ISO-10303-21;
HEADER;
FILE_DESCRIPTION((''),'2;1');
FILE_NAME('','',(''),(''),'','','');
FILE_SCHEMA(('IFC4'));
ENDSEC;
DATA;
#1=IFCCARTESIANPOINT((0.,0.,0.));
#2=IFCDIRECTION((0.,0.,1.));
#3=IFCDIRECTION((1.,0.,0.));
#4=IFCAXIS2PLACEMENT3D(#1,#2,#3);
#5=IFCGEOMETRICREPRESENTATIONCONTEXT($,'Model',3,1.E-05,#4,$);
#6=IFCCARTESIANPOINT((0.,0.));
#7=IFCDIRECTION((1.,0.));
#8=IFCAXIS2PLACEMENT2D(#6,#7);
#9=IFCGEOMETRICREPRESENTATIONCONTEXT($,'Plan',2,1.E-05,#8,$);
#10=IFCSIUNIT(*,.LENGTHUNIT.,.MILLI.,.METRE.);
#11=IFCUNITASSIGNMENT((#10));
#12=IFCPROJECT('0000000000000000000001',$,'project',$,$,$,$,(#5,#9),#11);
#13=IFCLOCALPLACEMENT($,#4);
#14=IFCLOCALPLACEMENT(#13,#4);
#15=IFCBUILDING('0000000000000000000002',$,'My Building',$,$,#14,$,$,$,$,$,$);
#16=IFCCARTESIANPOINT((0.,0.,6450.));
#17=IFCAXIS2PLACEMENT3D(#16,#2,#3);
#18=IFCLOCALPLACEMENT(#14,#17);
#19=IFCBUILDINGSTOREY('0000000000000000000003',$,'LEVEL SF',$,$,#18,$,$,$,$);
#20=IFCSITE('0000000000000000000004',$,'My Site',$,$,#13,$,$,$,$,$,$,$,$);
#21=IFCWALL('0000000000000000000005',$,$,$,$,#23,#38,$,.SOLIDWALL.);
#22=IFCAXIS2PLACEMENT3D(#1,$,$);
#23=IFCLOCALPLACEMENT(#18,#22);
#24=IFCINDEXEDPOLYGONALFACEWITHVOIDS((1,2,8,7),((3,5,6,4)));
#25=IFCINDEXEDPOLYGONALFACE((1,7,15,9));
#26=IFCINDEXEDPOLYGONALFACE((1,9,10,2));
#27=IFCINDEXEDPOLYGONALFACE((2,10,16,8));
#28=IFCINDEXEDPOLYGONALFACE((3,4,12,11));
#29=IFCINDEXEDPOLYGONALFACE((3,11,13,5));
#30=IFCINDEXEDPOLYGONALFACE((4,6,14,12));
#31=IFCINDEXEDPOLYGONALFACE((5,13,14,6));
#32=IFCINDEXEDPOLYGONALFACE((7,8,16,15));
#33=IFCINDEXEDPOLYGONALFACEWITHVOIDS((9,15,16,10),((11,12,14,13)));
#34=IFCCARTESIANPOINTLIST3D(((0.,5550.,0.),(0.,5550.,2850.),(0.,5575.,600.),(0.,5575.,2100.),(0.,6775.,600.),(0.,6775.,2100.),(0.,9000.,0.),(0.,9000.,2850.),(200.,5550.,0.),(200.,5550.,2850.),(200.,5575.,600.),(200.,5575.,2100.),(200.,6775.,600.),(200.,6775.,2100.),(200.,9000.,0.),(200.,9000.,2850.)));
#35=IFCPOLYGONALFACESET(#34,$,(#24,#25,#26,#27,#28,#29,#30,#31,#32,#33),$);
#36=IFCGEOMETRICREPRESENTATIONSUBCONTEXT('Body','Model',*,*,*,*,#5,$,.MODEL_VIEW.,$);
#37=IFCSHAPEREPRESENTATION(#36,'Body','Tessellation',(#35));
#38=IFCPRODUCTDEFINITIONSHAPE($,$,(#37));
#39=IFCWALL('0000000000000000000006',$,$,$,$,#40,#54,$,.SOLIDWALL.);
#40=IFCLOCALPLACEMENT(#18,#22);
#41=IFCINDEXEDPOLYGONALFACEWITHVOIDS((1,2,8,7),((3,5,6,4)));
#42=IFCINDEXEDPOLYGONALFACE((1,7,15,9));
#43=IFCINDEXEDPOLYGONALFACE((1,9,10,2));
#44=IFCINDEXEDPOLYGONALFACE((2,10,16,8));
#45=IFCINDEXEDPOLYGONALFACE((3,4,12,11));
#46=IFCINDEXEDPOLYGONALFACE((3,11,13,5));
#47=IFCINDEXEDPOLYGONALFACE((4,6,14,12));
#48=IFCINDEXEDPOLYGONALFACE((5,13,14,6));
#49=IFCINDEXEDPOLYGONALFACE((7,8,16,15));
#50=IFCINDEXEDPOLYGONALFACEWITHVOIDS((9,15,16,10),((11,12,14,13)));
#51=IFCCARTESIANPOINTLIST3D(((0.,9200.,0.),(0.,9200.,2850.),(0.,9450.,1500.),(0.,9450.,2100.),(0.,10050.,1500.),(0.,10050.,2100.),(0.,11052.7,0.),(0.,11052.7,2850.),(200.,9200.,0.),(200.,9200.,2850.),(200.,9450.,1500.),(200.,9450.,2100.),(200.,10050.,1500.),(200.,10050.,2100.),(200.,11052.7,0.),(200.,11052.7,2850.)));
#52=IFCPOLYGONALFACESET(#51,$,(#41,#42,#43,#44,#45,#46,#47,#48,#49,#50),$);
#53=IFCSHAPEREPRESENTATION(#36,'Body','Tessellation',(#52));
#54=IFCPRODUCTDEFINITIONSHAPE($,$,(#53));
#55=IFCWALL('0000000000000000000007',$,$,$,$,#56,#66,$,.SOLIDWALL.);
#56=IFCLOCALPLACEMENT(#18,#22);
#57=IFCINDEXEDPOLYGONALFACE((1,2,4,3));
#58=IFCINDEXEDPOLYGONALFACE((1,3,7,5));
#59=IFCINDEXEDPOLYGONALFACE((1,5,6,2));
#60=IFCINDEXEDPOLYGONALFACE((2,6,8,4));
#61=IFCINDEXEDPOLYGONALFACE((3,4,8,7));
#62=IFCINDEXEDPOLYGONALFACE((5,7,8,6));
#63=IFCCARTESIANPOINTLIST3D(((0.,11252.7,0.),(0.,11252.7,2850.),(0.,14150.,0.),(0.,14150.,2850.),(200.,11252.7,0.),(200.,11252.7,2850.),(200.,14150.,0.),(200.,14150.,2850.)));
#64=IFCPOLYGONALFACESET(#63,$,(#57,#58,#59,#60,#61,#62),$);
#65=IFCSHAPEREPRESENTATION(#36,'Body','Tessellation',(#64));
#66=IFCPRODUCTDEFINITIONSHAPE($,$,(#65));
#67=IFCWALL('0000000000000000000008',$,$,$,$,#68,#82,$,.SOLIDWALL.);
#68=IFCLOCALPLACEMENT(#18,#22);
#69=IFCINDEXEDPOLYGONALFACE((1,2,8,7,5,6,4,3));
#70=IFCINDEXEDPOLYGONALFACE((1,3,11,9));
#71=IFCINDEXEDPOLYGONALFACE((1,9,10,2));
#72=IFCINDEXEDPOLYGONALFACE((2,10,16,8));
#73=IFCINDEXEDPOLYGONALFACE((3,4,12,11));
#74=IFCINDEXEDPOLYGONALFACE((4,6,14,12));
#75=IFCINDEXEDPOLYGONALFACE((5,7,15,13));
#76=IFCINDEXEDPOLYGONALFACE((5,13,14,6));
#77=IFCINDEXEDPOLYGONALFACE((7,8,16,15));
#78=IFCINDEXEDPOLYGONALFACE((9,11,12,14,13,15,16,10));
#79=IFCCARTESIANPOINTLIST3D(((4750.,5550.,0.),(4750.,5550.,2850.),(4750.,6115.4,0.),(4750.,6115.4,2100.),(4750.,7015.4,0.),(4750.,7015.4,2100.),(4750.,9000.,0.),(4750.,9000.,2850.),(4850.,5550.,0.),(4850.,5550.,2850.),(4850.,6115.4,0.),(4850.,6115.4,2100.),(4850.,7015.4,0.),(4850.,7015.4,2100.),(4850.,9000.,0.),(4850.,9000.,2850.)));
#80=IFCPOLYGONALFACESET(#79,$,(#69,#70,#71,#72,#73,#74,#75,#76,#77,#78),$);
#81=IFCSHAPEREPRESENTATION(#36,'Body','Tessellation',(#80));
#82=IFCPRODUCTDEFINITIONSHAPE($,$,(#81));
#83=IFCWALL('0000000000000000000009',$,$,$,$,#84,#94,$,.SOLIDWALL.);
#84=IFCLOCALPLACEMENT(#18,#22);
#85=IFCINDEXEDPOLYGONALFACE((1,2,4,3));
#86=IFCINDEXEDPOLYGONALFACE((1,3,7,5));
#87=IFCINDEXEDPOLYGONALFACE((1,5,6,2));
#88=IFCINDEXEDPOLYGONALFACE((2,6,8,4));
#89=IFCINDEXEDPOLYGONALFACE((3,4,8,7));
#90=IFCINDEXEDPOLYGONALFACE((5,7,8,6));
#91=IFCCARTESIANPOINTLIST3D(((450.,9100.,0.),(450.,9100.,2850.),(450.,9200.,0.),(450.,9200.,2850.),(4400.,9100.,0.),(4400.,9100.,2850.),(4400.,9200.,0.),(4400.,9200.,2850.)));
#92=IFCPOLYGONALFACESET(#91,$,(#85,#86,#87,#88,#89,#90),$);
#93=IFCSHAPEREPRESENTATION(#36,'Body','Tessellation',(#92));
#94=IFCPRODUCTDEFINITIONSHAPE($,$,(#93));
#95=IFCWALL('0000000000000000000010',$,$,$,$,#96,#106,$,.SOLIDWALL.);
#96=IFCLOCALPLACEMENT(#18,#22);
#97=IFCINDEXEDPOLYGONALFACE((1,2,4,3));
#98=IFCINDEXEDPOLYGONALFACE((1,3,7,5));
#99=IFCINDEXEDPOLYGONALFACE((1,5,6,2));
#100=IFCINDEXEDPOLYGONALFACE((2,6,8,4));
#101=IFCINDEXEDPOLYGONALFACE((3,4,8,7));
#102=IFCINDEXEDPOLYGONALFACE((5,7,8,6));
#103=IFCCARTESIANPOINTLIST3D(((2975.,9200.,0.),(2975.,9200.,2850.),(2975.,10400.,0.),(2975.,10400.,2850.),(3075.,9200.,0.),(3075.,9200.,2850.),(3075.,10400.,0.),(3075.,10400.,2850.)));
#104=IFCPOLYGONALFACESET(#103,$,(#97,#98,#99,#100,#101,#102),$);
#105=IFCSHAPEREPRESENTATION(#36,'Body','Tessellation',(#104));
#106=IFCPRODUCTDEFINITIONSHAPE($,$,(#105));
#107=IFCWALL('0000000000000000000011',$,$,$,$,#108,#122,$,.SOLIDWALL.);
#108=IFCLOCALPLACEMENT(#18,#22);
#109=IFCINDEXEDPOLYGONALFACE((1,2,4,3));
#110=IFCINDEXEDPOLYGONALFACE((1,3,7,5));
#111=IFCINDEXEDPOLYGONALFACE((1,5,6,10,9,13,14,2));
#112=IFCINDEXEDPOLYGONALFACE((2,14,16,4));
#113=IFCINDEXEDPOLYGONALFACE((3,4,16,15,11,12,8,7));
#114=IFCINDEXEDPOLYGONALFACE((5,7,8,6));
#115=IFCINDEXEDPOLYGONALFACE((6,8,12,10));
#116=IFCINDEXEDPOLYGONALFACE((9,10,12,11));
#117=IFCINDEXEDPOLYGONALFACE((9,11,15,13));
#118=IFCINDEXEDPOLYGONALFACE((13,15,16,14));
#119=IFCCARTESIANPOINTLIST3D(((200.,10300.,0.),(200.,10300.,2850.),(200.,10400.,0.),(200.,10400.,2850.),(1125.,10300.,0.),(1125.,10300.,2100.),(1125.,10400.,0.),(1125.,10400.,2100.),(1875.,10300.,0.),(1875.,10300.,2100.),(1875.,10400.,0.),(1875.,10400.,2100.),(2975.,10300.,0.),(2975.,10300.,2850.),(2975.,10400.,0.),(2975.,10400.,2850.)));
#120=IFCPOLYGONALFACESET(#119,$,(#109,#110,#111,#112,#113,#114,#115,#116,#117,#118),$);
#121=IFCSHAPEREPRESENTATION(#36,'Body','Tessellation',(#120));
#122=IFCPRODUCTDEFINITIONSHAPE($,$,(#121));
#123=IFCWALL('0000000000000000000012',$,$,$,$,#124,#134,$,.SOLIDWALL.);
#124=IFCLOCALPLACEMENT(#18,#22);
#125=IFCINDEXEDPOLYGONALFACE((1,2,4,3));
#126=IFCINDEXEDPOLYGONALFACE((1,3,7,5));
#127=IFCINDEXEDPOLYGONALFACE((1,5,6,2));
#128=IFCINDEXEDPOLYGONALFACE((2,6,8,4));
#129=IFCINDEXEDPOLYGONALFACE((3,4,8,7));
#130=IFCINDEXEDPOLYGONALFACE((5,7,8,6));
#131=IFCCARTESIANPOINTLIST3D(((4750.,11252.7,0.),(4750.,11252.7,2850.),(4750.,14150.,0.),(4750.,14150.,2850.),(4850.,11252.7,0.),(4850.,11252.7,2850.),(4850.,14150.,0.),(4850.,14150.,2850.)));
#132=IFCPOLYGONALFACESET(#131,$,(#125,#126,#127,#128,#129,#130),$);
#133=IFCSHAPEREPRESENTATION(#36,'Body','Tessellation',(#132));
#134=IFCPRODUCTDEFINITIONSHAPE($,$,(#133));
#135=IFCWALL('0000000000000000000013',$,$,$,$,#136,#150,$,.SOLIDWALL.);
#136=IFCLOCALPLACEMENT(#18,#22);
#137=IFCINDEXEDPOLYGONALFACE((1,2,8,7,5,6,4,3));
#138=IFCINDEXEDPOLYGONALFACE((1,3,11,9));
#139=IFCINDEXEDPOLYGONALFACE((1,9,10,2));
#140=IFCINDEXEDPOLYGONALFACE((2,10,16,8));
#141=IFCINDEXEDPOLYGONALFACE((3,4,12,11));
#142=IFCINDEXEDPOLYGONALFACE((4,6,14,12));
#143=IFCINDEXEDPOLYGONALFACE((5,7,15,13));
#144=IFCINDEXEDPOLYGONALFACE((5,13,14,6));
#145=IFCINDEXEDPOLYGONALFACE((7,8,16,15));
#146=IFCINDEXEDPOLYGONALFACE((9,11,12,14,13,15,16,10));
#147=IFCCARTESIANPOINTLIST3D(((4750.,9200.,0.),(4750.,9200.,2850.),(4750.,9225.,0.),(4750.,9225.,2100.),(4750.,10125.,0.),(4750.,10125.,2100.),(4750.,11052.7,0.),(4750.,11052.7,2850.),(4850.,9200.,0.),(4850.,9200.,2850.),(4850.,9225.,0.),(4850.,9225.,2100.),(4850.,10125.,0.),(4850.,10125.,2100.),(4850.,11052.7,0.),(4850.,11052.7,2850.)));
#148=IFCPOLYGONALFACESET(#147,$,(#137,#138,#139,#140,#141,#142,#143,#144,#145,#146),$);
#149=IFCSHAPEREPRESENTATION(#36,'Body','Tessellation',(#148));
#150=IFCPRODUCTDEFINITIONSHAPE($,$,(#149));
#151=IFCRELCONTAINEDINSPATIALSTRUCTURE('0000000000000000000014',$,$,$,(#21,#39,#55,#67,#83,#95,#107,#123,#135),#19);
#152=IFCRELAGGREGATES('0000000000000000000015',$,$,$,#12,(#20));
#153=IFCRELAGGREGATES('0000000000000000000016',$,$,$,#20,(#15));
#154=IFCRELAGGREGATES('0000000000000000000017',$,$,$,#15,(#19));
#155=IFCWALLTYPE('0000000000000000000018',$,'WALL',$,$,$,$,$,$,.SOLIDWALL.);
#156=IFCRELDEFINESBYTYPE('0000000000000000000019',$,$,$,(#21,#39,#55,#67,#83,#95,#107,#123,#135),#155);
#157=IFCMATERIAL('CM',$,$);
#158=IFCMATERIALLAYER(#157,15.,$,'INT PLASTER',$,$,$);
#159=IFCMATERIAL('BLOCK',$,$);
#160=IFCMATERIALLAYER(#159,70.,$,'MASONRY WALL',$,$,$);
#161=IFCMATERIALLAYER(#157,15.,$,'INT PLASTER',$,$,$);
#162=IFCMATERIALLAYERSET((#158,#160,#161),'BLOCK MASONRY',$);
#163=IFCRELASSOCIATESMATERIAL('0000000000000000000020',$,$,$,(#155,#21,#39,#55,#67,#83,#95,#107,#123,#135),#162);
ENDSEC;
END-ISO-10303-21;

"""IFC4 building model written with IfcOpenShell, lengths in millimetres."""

from ifc_helpers import new_model, si_unit, frame, origin_with_axes, origin_2d_with_axis, place, context, subcontext, project, spatial, indexed_curve, outline, extrude, material, layer, layer_set, layer_usage, type_object, element, save


model = new_model("IFC4")

# Units and contexts
model_context = context("Model", 3, precision=1e-05, world=origin_with_axes())
plan_context = context("Plan", 2, precision=1e-05, world=origin_2d_with_axis())
body_context = subcontext(model_context, "Body", "Model", "MODEL_VIEW")
ifc_project = project(units=[si_unit("LENGTHUNIT", "METRE", prefix="MILLI")], contexts=[model_context, plan_context])

# Site, building, storey
site_placement = place(None, origin_with_axes())
site = spatial("IfcSite", under=ifc_project, at=site_placement, Name="My Site")
building_placement = place(site_placement, origin_with_axes())
building = spatial("IfcBuilding", under=site, at=building_placement, Name="My Building")
storey_placement = place(building_placement, frame((0.0, 0.0, 6450.0), z_axis=(0.0, 0.0, 1.0), x_axis=(1.0, 0.0, 0.0)))
storey = spatial("IfcBuildingStorey", under=building, at=storey_placement, Name="LEVEL SF")

# Shared definitions
ifc_material_1 = material(Name="CM")
ifc_layer_1 = layer(ifc_material_1, 15.0, Name="INT PLASTER")
ifc_material_2 = material(Name="BLOCK")
ifc_layer_2 = layer(ifc_material_2, 70.0, Name="MASONRY WALL")
ifc_layer_3 = layer(ifc_material_1, 15.0, Name="INT PLASTER")
ifc_layer_set = layer_set([ifc_layer_1, ifc_layer_2, ifc_layer_3], Name="BLOCK MASONRY")
wall_type = type_object("IfcWallType", Name="WALL", PredefinedType="SOLIDWALL", material=ifc_layer_set)

# Walls, openings
ifc_layer_usage_1 = layer_usage(ifc_layer_set, "AXIS2", "POSITIVE", 0.0)
wall_1_placement = place(storey_placement, frame((200.0, 5550.0, 0.0), z_axis=(0.0, 0.0, 1.0), x_axis=(0.0, 1.0, 0.0)))
wall_1 = element("IfcWall", 1, at=wall_1_placement, inside=storey, type_object=wall_type, material=ifc_layer_usage_1, PredefinedType="SOLIDWALL", context=body_context, shape_type="SweptSolid", body=[
    extrude(outline(indexed_curve([(0.0, 0.0), (0.0, 200.0), (3450.0, 200.0), (3450.0, 0.0), (0.0, 0.0)], self_intersect=False)), origin_with_axes(), (0.0, 0.0, 1.0), 2850.0),
])
opening_1_placement = place(wall_1_placement, frame((25.0, 0.0, 600.0), z_axis=(0.0, 0.0, 1.0), x_axis=(1.0, 0.0, 0.0)))
element("IfcOpeningElement", 2, at=opening_1_placement, cuts=wall_1, PredefinedType="OPENING", context=body_context, shape_type="SweptSolid", body=[
    extrude(outline(indexed_curve([(0.0, 0.0), (0.0, 400.0), (1200.0, 400.0), (1200.0, 0.0), (0.0, 0.0)], self_intersect=False)), frame((0.0, -100.0, 0.0), z_axis=(0.0, 0.0, 1.0), x_axis=(1.0, 0.0, 0.0)), (0.0, 0.0, 1.0), 1500.0),
])
ifc_layer_usage_2 = layer_usage(ifc_layer_set, "AXIS2", "POSITIVE", 0.0)
wall_2_placement = place(storey_placement, frame((200.0, 9200.0, 0.0), z_axis=(0.0, 0.0, 1.0), x_axis=(0.0, 1.0, 0.0)))
wall_2 = element("IfcWall", 3, at=wall_2_placement, inside=storey, type_object=wall_type, material=ifc_layer_usage_2, PredefinedType="SOLIDWALL", context=body_context, shape_type="SweptSolid", body=[
    extrude(outline(indexed_curve([(0.0, 0.0), (0.0, 200.0), (1852.7, 200.0), (1852.7, 0.0), (0.0, 0.0)], self_intersect=False)), origin_with_axes(), (0.0, 0.0, 1.0), 2850.0),
])
opening_2_placement = place(wall_2_placement, frame((250.0, 0.0, 1500.0), z_axis=(0.0, 0.0, 1.0), x_axis=(1.0, 0.0, 0.0)))
element("IfcOpeningElement", 4, at=opening_2_placement, cuts=wall_2, PredefinedType="OPENING", context=body_context, shape_type="SweptSolid", body=[
    extrude(outline(indexed_curve([(0.0, 0.0), (0.0, 400.0), (600.0, 400.0), (600.0, 0.0), (0.0, 0.0)], self_intersect=False)), frame((0.0, -100.0, 0.0), z_axis=(0.0, 0.0, 1.0), x_axis=(1.0, 0.0, 0.0)), (0.0, 0.0, 1.0), 600.0),
])

# Wall
ifc_layer_usage_3 = layer_usage(ifc_layer_set, "AXIS2", "POSITIVE", 0.0)
wall_3_placement = place(storey_placement, frame((200.0, 11252.7, 0.0), z_axis=(0.0, 0.0, 1.0), x_axis=(0.0, 1.0, 0.0)))
element("IfcWall", 5, at=wall_3_placement, inside=storey, type_object=wall_type, material=ifc_layer_usage_3, PredefinedType="SOLIDWALL", context=body_context, shape_type="SweptSolid", body=[
    extrude(outline(indexed_curve([(0.0, 0.0), (0.0, 200.0), (2897.3, 200.0), (2897.3, 0.0), (0.0, 0.0)], self_intersect=False)), origin_with_axes(), (0.0, 0.0, 1.0), 2850.0),
])

# Wall, opening
ifc_layer_usage_4 = layer_usage(ifc_layer_set, "AXIS2", "POSITIVE", 0.0)
wall_4_placement = place(storey_placement, frame((4850.0, 5550.0, 0.0), z_axis=(0.0, 0.0, 1.0), x_axis=(0.0, 1.0, 0.0)))
wall_4 = element("IfcWall", 6, at=wall_4_placement, inside=storey, type_object=wall_type, material=ifc_layer_usage_4, PredefinedType="SOLIDWALL", context=body_context, shape_type="SweptSolid", body=[
    extrude(outline(indexed_curve([(0.0, 0.0), (0.0, 100.0), (3450.0, 100.0), (3450.0, 0.0), (0.0, 0.0)], self_intersect=False)), origin_with_axes(), (0.0, 0.0, 1.0), 2850.0),
])
opening_3_placement = place(wall_4_placement, frame((565.4, 0.0, 0.0), z_axis=(0.0, 0.0, 1.0), x_axis=(1.0, 0.0, 0.0)))
element("IfcOpeningElement", 7, at=opening_3_placement, cuts=wall_4, PredefinedType="OPENING", context=body_context, shape_type="SweptSolid", body=[
    extrude(outline(indexed_curve([(0.0, 0.0), (0.0, 400.0), (900.0, 400.0), (900.0, 0.0), (0.0, 0.0)], self_intersect=False)), frame((0.0, -100.0, 0.0), z_axis=(0.0, 0.0, 1.0), x_axis=(1.0, 0.0, 0.0)), (0.0, 0.0, 1.0), 2100.0),
])

# Walls
ifc_layer_usage_5 = layer_usage(ifc_layer_set, "AXIS2", "POSITIVE", 0.0)
wall_5_placement = place(storey_placement, frame((450.0, 9200.0, 0.0), z_axis=(0.0, 0.0, 1.0), x_axis=(0.0, -1.0, 0.0)))
element("IfcWall", 8, at=wall_5_placement, inside=storey, type_object=wall_type, material=ifc_layer_usage_5, PredefinedType="SOLIDWALL", context=body_context, shape_type="SweptSolid", body=[
    extrude(outline(indexed_curve([(0.0, 0.0), (0.0, 3950.0), (100.0, 3950.0), (100.0, 0.0), (0.0, 0.0)], self_intersect=False)), origin_with_axes(), (0.0, 0.0, 1.0), 2850.0),
])
ifc_layer_usage_6 = layer_usage(ifc_layer_set, "AXIS2", "POSITIVE", 0.0)
wall_6_placement = place(storey_placement, frame((3075.0, 9200.0, 0.0), z_axis=(0.0, 0.0, 1.0), x_axis=(0.0, 1.0, 0.0)))
element("IfcWall", 9, at=wall_6_placement, inside=storey, type_object=wall_type, material=ifc_layer_usage_6, PredefinedType="SOLIDWALL", context=body_context, shape_type="SweptSolid", body=[
    extrude(outline(indexed_curve([(0.0, 0.0), (0.0, 100.0), (1200.0, 100.0), (1200.0, 0.0), (0.0, 0.0)], self_intersect=False)), origin_with_axes(), (0.0, 0.0, 1.0), 2850.0),
])

# Wall, opening
ifc_layer_usage_7 = layer_usage(ifc_layer_set, "AXIS2", "POSITIVE", 0.0)
wall_7_placement = place(storey_placement, frame((200.0, 10400.0, 0.0), z_axis=(0.0, 0.0, 1.0), x_axis=(0.0, -1.0, 0.0)))
wall_7 = element("IfcWall", 10, at=wall_7_placement, inside=storey, type_object=wall_type, material=ifc_layer_usage_7, PredefinedType="SOLIDWALL", context=body_context, shape_type="SweptSolid", body=[
    extrude(outline(indexed_curve([(0.0, 0.0), (0.0, 2775.0), (100.0, 2775.0), (100.0, 0.0), (0.0, 0.0)], self_intersect=False)), origin_with_axes(), (0.0, 0.0, 1.0), 2850.0),
])
opening_4_placement = place(wall_7_placement, frame((0.0, 1675.0, 0.0), z_axis=(0.0, 0.0, 1.0), x_axis=(0.0, -1.0, 0.0)))
element("IfcOpeningElement", 11, at=opening_4_placement, cuts=wall_7, PredefinedType="OPENING", context=body_context, shape_type="SweptSolid", body=[
    extrude(outline(indexed_curve([(0.0, 0.0), (0.0, 400.0), (750.0, 400.0), (750.0, 0.0), (0.0, 0.0)], self_intersect=False)), frame((0.0, -100.0, 0.0), z_axis=(0.0, 0.0, 1.0), x_axis=(1.0, 0.0, 0.0)), (0.0, 0.0, 1.0), 2100.0),
])

# Wall
ifc_layer_usage_8 = layer_usage(ifc_layer_set, "AXIS2", "POSITIVE", 0.0)
wall_8_placement = place(storey_placement, frame((4850.0, 11252.7, 0.0), z_axis=(0.0, 0.0, 1.0), x_axis=(0.0, 1.0, 0.0)))
element("IfcWall", 12, at=wall_8_placement, inside=storey, type_object=wall_type, material=ifc_layer_usage_8, PredefinedType="SOLIDWALL", context=body_context, shape_type="SweptSolid", body=[
    extrude(outline(indexed_curve([(0.0, 0.0), (0.0, 100.0), (2897.3, 100.0), (2897.3, 0.0), (0.0, 0.0)], self_intersect=False)), origin_with_axes(), (0.0, 0.0, 1.0), 2850.0),
])

# Wall, opening
ifc_layer_usage_9 = layer_usage(ifc_layer_set, "AXIS2", "POSITIVE", 0.0)
wall_9_placement = place(storey_placement, frame((4850.0, 9200.0, 0.0), z_axis=(0.0, 0.0, 1.0), x_axis=(0.0, 1.0, 0.0)))
wall_9 = element("IfcWall", 13, at=wall_9_placement, inside=storey, type_object=wall_type, material=ifc_layer_usage_9, PredefinedType="SOLIDWALL", context=body_context, shape_type="SweptSolid", body=[
    extrude(outline(indexed_curve([(0.0, 0.0), (0.0, 100.0), (1852.7, 100.0), (1852.7, 0.0), (0.0, 0.0)], self_intersect=False)), origin_with_axes(), (0.0, 0.0, 1.0), 2850.0),
])
opening_5_placement = place(wall_9_placement, frame((25.0, 0.0, 0.0), z_axis=(0.0, 0.0, 1.0), x_axis=(1.0, 0.0, 0.0)))
element("IfcOpeningElement", 14, at=opening_5_placement, cuts=wall_9, PredefinedType="OPENING", context=body_context, shape_type="SweptSolid", body=[
    extrude(outline(indexed_curve([(0.0, 0.0), (0.0, 400.0), (900.0, 400.0), (900.0, 0.0), (0.0, 0.0)], self_intersect=False)), frame((0.0, -100.0, 0.0), z_axis=(0.0, 0.0, 1.0), x_axis=(1.0, 0.0, 0.0)), (0.0, 0.0, 1.0), 2100.0),
])

save(model, "model.ifc")
